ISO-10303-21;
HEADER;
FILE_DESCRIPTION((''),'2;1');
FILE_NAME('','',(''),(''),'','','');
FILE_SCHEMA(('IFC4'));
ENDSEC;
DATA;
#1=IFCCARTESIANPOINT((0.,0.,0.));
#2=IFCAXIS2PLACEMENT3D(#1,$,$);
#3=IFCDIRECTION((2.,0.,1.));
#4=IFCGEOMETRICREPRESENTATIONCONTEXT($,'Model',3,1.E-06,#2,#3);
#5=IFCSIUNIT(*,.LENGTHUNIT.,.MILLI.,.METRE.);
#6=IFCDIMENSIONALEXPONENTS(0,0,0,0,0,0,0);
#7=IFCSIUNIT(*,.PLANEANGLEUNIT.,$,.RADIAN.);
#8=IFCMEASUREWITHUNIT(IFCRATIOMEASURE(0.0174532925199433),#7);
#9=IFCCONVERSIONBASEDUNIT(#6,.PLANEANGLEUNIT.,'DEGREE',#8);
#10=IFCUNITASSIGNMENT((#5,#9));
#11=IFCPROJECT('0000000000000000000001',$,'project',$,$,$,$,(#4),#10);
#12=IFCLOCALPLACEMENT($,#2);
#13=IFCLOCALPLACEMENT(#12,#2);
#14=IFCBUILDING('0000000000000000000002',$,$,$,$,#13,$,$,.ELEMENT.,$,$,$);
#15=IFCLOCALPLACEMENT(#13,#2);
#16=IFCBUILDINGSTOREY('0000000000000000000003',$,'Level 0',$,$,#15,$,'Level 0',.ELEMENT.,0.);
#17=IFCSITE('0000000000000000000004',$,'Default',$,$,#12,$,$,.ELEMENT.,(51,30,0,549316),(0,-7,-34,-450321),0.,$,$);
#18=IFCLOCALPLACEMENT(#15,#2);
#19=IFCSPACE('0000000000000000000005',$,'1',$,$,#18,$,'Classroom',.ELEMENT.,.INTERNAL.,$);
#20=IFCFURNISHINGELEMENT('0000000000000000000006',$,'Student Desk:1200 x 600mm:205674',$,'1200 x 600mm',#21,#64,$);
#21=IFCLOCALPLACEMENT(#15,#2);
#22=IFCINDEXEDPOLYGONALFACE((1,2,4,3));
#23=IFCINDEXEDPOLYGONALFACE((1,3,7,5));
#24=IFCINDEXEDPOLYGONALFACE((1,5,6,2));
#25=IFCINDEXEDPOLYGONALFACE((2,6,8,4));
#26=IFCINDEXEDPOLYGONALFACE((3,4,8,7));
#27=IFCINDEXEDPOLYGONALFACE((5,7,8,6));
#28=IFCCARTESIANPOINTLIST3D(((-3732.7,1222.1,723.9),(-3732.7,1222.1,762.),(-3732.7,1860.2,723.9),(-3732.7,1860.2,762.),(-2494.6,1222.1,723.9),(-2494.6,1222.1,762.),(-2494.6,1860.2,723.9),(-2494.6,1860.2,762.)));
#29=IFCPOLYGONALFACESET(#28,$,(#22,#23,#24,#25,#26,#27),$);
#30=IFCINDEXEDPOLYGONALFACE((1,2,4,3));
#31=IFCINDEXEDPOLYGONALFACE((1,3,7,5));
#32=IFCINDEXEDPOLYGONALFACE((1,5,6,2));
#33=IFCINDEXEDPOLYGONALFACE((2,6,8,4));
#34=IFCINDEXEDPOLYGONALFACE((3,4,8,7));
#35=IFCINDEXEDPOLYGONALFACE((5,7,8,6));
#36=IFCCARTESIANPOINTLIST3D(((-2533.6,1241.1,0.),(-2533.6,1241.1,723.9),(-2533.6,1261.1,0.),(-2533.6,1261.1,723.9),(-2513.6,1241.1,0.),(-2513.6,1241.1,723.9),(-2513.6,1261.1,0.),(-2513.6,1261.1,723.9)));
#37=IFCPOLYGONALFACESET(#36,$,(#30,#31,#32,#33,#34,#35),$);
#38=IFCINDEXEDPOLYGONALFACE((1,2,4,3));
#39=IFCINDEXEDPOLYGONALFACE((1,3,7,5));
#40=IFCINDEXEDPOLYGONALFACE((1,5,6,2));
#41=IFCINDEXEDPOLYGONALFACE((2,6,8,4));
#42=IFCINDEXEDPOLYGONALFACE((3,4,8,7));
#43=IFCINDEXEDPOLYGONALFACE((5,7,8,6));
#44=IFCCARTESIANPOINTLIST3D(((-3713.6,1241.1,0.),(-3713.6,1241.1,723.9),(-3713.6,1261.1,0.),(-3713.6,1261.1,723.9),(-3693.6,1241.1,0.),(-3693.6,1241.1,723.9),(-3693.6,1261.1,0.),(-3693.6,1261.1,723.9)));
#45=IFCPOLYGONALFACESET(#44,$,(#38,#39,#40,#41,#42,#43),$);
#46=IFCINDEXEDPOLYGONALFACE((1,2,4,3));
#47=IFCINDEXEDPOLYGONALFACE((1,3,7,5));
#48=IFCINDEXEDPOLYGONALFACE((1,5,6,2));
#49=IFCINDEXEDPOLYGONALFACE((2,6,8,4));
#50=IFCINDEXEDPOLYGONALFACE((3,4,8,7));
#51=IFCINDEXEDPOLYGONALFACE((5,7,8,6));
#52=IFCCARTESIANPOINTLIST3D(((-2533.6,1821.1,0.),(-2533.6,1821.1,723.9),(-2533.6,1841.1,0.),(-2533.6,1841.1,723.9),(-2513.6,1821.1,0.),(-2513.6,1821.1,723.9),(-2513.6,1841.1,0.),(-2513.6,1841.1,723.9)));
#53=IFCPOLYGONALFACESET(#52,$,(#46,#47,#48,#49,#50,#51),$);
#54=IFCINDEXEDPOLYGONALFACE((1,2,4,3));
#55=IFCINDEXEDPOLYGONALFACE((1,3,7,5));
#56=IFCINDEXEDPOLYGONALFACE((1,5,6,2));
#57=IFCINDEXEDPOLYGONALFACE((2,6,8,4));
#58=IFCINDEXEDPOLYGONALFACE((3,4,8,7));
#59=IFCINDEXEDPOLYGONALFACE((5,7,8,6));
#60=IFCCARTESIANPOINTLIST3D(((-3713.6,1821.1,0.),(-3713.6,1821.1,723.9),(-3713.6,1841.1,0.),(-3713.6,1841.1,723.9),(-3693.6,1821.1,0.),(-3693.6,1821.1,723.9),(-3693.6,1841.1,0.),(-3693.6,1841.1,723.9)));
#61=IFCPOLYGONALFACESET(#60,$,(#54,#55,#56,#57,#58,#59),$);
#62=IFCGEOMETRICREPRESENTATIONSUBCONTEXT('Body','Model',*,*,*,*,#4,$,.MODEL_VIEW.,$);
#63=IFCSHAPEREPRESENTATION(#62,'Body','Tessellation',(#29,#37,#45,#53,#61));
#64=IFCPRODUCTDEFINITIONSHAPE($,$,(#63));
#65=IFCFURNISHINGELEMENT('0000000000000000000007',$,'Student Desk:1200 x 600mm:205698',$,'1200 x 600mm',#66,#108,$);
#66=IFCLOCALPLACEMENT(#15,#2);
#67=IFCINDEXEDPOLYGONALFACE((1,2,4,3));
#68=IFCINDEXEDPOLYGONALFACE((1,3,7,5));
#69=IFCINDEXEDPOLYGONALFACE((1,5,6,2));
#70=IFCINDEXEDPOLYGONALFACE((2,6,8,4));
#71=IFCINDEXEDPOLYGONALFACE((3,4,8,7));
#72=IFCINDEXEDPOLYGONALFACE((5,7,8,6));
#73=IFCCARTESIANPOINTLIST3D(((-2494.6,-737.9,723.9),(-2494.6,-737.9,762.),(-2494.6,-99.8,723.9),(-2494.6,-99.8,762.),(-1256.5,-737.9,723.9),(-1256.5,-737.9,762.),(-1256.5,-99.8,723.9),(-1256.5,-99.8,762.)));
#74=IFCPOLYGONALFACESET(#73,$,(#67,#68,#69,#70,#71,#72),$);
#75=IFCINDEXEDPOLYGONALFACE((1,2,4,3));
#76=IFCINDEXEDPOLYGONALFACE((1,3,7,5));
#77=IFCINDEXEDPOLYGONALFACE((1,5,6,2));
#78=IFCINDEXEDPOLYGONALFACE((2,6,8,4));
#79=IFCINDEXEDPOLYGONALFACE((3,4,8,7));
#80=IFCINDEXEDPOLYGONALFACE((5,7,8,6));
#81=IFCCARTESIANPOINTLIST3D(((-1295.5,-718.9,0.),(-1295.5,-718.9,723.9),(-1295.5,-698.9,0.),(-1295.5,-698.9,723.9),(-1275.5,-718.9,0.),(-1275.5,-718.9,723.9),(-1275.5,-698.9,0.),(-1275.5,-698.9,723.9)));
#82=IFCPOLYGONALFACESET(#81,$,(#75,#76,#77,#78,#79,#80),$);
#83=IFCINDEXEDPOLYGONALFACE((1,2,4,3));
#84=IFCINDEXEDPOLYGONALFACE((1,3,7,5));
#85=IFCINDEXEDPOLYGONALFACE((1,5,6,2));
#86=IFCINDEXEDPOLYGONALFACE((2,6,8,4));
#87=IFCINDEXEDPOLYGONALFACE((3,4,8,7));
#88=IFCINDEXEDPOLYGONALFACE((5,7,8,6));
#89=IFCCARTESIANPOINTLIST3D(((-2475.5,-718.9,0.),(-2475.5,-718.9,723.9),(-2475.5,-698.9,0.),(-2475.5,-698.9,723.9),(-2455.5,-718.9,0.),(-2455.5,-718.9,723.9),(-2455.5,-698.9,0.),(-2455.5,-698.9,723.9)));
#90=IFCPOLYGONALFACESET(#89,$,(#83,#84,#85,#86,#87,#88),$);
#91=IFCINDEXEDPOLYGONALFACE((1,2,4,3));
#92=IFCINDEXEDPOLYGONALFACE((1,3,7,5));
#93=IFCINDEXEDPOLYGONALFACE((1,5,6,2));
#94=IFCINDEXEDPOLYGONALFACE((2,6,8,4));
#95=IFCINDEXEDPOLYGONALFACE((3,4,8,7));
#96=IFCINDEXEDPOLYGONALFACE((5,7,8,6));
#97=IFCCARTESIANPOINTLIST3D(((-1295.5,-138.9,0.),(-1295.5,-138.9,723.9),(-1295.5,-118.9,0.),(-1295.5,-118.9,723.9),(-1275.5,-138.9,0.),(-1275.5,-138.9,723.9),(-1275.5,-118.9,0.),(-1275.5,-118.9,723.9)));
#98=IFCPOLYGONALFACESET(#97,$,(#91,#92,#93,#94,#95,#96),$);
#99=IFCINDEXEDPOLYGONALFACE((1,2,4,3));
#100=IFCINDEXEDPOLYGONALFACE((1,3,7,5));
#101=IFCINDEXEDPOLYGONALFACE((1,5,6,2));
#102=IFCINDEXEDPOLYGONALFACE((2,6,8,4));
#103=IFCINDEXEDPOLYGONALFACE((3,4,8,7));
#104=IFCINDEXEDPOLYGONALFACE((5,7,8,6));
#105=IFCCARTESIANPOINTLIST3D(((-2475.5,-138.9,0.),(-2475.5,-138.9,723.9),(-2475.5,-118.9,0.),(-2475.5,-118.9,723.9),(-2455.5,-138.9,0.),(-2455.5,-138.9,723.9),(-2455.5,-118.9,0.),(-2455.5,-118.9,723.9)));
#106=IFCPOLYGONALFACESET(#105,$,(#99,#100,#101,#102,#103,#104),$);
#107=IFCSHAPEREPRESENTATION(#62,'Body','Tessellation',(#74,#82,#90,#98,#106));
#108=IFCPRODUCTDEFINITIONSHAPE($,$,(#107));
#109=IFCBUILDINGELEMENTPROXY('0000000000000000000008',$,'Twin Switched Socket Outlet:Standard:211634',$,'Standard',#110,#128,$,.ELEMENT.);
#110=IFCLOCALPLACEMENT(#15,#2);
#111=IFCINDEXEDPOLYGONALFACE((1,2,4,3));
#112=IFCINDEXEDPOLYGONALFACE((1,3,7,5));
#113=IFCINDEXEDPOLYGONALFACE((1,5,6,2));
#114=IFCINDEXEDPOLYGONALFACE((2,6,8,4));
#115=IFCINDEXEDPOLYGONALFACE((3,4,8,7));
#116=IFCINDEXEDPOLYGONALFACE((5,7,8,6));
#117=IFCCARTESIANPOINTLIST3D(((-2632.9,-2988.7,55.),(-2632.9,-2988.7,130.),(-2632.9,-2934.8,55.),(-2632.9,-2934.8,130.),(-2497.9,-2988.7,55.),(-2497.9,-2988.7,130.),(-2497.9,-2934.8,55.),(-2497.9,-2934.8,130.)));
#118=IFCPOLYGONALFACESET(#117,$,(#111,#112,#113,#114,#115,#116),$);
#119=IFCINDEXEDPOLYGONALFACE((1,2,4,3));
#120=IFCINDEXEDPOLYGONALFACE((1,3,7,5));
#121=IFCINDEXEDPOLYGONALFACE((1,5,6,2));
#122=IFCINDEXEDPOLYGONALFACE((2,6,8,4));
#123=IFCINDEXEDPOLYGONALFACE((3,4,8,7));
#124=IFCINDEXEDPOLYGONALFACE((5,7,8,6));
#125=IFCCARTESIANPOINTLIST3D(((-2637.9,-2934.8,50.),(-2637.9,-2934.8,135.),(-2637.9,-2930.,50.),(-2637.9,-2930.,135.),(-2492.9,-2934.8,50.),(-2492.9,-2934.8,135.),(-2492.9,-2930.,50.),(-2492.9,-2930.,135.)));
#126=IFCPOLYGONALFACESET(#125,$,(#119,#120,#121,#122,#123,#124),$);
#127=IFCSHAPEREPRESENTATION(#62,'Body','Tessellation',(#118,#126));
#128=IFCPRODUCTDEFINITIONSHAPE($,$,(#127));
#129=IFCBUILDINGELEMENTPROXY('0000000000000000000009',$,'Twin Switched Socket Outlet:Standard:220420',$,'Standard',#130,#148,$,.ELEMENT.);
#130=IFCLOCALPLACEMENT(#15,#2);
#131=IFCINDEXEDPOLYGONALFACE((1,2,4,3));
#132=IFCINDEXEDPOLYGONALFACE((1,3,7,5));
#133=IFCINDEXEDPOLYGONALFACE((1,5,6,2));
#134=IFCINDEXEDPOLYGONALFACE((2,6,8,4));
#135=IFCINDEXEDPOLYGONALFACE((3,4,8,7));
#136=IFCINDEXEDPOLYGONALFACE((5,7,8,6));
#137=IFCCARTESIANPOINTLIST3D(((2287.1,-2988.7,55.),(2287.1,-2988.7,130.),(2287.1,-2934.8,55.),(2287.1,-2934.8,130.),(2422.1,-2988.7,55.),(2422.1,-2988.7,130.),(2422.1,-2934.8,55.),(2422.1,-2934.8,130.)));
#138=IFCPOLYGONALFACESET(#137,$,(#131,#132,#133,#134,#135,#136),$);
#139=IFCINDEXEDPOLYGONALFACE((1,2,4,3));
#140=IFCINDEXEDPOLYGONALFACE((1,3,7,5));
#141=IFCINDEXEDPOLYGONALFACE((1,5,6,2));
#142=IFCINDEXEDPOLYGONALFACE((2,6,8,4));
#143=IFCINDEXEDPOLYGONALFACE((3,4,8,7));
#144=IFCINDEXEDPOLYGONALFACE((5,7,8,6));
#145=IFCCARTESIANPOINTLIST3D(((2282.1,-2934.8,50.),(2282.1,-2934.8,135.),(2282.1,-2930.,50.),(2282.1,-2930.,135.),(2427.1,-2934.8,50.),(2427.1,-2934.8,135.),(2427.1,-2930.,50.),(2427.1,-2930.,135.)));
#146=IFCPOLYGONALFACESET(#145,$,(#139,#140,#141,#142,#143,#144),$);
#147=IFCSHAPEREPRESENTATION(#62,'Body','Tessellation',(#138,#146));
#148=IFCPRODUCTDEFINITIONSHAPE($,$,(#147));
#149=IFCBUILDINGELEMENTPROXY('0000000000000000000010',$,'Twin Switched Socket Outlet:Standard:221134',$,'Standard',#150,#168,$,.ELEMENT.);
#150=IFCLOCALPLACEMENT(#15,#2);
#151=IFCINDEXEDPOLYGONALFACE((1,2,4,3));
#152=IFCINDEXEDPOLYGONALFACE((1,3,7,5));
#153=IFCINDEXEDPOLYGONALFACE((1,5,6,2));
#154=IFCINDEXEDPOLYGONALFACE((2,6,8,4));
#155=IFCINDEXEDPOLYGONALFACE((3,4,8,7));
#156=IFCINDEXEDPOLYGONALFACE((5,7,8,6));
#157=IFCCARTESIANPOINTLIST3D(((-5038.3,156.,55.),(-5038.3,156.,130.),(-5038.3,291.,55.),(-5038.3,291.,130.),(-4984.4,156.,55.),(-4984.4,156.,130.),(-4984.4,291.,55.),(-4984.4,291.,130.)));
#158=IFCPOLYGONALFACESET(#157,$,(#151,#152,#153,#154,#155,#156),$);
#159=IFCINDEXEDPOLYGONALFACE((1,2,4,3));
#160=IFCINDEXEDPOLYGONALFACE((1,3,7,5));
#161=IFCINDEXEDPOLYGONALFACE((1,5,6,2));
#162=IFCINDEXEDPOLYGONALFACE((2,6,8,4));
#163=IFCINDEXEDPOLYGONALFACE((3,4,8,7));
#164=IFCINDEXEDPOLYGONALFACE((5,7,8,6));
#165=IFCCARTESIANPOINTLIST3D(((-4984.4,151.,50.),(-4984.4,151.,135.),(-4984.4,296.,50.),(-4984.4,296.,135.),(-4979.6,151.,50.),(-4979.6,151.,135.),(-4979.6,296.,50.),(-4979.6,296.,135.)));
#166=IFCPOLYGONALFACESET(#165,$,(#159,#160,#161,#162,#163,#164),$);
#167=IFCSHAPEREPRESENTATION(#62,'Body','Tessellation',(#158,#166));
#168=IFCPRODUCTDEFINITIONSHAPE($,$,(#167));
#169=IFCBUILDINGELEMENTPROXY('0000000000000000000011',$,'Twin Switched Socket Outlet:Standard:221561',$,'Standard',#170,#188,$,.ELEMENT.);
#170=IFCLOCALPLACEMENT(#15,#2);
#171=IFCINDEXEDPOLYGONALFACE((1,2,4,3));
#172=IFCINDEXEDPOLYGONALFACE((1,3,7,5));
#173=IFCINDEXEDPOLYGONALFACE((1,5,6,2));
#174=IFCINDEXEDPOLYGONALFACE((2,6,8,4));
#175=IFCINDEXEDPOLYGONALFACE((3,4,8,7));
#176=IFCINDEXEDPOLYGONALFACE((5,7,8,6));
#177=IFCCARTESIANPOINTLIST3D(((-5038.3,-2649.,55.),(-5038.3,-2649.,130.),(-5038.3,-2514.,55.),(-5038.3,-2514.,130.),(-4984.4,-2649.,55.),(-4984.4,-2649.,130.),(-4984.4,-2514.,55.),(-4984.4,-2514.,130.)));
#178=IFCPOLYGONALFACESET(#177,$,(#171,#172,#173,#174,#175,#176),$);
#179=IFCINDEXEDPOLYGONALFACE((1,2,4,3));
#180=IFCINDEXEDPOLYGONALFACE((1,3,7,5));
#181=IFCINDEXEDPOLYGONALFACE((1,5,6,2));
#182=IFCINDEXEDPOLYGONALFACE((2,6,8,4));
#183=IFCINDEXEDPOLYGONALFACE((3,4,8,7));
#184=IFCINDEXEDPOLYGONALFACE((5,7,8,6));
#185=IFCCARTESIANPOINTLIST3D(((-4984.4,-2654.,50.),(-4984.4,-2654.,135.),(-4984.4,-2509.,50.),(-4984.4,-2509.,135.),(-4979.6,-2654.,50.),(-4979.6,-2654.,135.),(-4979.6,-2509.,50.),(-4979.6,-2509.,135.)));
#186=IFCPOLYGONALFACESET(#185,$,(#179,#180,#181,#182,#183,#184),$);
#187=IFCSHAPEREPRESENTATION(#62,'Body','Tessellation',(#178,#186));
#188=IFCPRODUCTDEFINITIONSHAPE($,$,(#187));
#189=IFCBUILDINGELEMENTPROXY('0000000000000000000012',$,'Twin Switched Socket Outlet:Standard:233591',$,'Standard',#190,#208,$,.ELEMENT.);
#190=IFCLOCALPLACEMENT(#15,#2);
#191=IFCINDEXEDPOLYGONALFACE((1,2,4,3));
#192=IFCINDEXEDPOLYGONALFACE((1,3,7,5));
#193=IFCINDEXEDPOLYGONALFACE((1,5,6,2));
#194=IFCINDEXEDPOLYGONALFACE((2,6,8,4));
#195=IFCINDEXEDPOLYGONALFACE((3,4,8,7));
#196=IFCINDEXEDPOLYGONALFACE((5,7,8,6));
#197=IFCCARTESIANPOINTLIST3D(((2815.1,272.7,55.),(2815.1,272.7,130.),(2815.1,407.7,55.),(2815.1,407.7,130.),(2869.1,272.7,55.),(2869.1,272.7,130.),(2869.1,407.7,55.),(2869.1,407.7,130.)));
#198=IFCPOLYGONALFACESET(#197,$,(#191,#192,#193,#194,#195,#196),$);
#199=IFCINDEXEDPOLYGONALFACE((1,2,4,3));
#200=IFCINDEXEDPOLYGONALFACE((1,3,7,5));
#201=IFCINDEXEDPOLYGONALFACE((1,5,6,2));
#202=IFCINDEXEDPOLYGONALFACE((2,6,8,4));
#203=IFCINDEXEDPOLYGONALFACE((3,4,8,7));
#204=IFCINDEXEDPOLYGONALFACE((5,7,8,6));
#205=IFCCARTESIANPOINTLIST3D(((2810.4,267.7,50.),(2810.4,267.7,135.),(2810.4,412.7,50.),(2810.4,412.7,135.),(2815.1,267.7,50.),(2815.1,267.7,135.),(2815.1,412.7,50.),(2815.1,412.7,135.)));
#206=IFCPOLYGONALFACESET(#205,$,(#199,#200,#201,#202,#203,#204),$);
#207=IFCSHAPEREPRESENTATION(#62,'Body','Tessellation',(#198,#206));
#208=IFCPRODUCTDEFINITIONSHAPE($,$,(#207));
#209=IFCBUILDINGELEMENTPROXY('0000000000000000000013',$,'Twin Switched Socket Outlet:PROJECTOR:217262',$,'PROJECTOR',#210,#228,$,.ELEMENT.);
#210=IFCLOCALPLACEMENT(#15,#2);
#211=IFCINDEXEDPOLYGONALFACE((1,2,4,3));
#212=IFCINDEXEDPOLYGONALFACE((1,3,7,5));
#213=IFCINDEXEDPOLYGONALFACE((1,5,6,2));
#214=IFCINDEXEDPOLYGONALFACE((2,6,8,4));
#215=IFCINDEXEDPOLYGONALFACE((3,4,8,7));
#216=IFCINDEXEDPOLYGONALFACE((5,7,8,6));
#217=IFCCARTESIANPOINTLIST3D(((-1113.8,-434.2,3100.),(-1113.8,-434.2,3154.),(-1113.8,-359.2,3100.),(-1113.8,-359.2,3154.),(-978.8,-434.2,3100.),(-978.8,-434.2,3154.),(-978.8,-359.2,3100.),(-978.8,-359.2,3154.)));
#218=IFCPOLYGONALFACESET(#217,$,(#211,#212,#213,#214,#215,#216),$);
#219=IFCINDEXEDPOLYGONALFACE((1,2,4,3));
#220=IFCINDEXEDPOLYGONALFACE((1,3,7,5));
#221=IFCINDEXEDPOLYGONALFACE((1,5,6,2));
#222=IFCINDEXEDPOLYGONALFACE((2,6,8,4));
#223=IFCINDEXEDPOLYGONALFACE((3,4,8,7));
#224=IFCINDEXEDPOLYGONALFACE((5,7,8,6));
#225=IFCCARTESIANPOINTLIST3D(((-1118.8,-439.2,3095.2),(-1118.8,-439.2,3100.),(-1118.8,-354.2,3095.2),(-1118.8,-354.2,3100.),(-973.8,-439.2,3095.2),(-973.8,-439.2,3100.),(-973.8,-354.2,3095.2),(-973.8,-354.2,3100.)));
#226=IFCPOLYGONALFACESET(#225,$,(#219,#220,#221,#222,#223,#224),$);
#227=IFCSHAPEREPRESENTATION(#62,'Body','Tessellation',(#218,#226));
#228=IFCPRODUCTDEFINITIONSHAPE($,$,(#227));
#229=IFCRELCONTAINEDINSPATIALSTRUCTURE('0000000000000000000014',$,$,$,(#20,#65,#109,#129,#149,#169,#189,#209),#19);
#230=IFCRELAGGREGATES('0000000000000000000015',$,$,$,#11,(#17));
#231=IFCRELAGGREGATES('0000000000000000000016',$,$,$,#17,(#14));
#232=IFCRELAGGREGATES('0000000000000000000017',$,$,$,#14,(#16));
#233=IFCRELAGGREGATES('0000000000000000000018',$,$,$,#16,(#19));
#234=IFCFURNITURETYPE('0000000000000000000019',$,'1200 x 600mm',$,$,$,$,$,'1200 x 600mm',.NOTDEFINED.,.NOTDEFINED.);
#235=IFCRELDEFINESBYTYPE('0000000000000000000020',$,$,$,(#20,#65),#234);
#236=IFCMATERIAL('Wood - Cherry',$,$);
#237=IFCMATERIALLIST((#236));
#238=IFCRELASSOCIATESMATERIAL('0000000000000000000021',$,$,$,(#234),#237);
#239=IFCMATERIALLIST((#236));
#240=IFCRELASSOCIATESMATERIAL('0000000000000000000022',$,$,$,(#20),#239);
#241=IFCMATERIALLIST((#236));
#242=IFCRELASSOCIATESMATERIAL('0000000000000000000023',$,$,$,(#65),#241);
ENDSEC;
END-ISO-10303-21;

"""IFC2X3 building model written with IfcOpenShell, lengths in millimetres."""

from ifc_helpers import new_model, entity, si_unit, converted_unit, direction, frame, frame_2d, origin, origin_2d_with_axis, place, context, subcontext, project, spatial, rectangle, extrude, source, transform, mapped, material, material_list, type_object, type_shapes, element, save


model = new_model("IFC2X3")

# Units and contexts
model_context = context("Model", 3, precision=1e-06, world=origin(), true_north=direction((2.0, 0.0, 1.0)))
body_context = subcontext(model_context, "Body", "Model", "MODEL_VIEW")
ifc_project = project(units=[si_unit("LENGTHUNIT", "METRE", prefix="MILLI"), converted_unit("PLANEANGLEUNIT", "DEGREE", entity("IfcRatioMeasure", 0.0174532925199433), si_unit("PLANEANGLEUNIT", "RADIAN"), dimensions=[0, 0, 0, 0, 0, 0, 0])], contexts=[model_context])

# Site, building, storey
site_placement = place(None, origin())
site = spatial("IfcSite", under=ifc_project, at=site_placement, Name="Default", CompositionType="ELEMENT", RefLatitude=(51, 30, 0, 549316), RefLongitude=(0, -7, -34, -450321), RefElevation=0.0)
building_placement = place(site_placement, origin())
building = spatial("IfcBuilding", under=site, at=building_placement, CompositionType="ELEMENT")
storey_placement = place(building_placement, origin())
storey = spatial("IfcBuildingStorey", under=building, at=storey_placement, Name="Level 0", LongName="Level 0", CompositionType="ELEMENT", Elevation=0.0)

# Shared definitions
space_placement = place(storey_placement, origin())
space = spatial("IfcSpace", under=storey, at=space_placement, Name="1", LongName="Classroom", CompositionType="ELEMENT", InteriorOrExteriorSpace="INTERNAL")

# Furnishing elements
ifc_material_1 = material(Name="Wood - Cherry")
ifc_material_list_1 = material_list([ifc_material_1])
furniture_type = type_object("IfcFurnitureType", Name="1200 x 600mm", ElementType="1200 x 600mm", AssemblyPlace="NOTDEFINED", material=ifc_material_list_1)
shared_shape_1 = source(origin(), body_context, "Body", "SweptSolid", [
    extrude(rectangle(XDim=1238.1, YDim=638.1, at=origin_2d_with_axis()), frame((600.0, 300.0, 723.9), z_axis=(0.0, 0.0, 1.0), x_axis=(-1.0, 0.0, 0.0)), (0.0, 0.0, 1.0), 38.1),
    extrude(rectangle(XDim=20.0, YDim=20.0, at=origin_2d_with_axis()), frame((1190.0, 10.0, 0.0)), (0.0, 0.0, 1.0), 723.9),
    extrude(rectangle(XDim=20.0, YDim=20.0, at=frame_2d((0.0, 0.0), x_axis=(1.0, 0.0))), frame((10.0, 10.0, 0.0), z_axis=(0.0, 0.0, 1.0), x_axis=(0.0, 1.0, 0.0)), (0.0, 0.0, 1.0), 723.9),
    extrude(rectangle(XDim=20.0, YDim=20.0, at=frame_2d((0.0, 0.0), x_axis=(1.0, 0.0))), frame((1190.0, 590.0, 0.0), z_axis=(0.0, 0.0, 1.0), x_axis=(0.0, -1.0, 0.0)), (0.0, 0.0, 1.0), 723.9),
    extrude(rectangle(XDim=20.0, YDim=20.0, at=origin_2d_with_axis()), frame((10.0, 590.0, 0.0), z_axis=(0.0, 0.0, 1.0), x_axis=(-1.0, 0.0, 0.0)), (0.0, 0.0, 1.0), 723.9),
])
type_shapes(furniture_type, [shared_shape_1])
ifc_material_list_2 = material_list([ifc_material_1])
furnishing_1_placement = place(space_placement, frame((-3713.6, 1241.1, 0.0)))
element("IfcFurnishingElement", 1, at=furnishing_1_placement, inside=space, type_object=furniture_type, material=ifc_material_list_2, Name="Student Desk:1200 x 600mm:205674", ObjectType="1200 x 600mm", context=body_context, shape_type="MappedRepresentation", body=[
    mapped(shared_shape_1, transform((0.0, 0.0, 0.0), scale=1.0)),
])
ifc_material_list_3 = material_list([ifc_material_1])
furnishing_2_placement = place(space_placement, frame((-2475.5, -718.9, 0.0)))
element("IfcFurnishingElement", 2, at=furnishing_2_placement, inside=space, type_object=furniture_type, material=ifc_material_list_3, Name="Student Desk:1200 x 600mm:205698", ObjectType="1200 x 600mm", context=body_context, shape_type="MappedRepresentation", body=[
    mapped(shared_shape_1, transform((0.0, 0.0, 0.0), scale=1.0)),
])

# Building element proxies
shared_shape_2 = source(origin(), body_context, "Body", "SweptSolid", [
    extrude(rectangle(XDim=135.0, YDim=75.0, at=origin_2d_with_axis()), frame((0.0, 0.0, -54.0), z_axis=(0.0, 0.0, 1.0), x_axis=(-1.0, 0.0, 0.0)), (0.0, 0.0, 1.0), 54.0),
    extrude(rectangle(XDim=145.0, YDim=85.0, at=origin_2d_with_axis()), frame((0.0, 0.0, 0.0), z_axis=(0.0, 0.0, 1.0), x_axis=(-1.0, 0.0, 0.0)), (0.0, 0.0, 1.0), 4.8),
])
for number, where, z_axis, x_axis, name in (
    (3, (-2565.4, -2934.8, 92.5), (0.0, 1.0, 0.0), (-1.0, 0.0, 0.0), "Twin Switched Socket Outlet:Standard:211634"),
    (4, (2354.6, -2934.8, 92.5), (0.0, 1.0, 0.0), (-1.0, 0.0, 0.0), "Twin Switched Socket Outlet:Standard:220420"),
    (5, (-4984.4, 223.5, 92.5), (1.0, 0.0, 0.0), (0.0, 1.0, 0.0), "Twin Switched Socket Outlet:Standard:221134"),
    (6, (-4984.4, -2581.5, 92.5), (1.0, 0.0, 0.0), (0.0, 1.0, 0.0), "Twin Switched Socket Outlet:Standard:221561"),
    (7, (2815.1, 340.2, 92.5), (-1.0, 0.0, 0.0), (0.0, -1.0, 0.0), "Twin Switched Socket Outlet:Standard:233591"),
):
    element("IfcBuildingElementProxy", number, at=place(space_placement, frame(where, z_axis=z_axis, x_axis=x_axis)), inside=space, Name=name, ObjectType="Standard", CompositionType="ELEMENT", context=body_context, shape_type="MappedRepresentation", body=[
        mapped(shared_shape_2, transform((0.0, 0.0, 0.0), scale=1.0)),
    ])
shared_shape_3 = source(origin(), body_context, "Body", "SweptSolid", [
    extrude(rectangle(XDim=135.0, YDim=75.0, at=origin_2d_with_axis()), frame((0.0, 0.0, -54.0), z_axis=(0.0, 0.0, 1.0), x_axis=(-1.0, 0.0, 0.0)), (0.0, 0.0, 1.0), 54.0),
    extrude(rectangle(XDim=145.0, YDim=85.0, at=origin_2d_with_axis()), frame((0.0, 0.0, 0.0), z_axis=(0.0, 0.0, 1.0), x_axis=(-1.0, 0.0, 0.0)), (0.0, 0.0, 1.0), 4.8),
])
proxy_1_placement = place(space_placement, frame((-1046.3, -396.7, 3100.0), z_axis=(0.0, 0.0, -1.0), x_axis=(1.0, 0.0, 0.0)))
element("IfcBuildingElementProxy", 8, at=proxy_1_placement, inside=space, Name="Twin Switched Socket Outlet:PROJECTOR:217262", ObjectType="PROJECTOR", CompositionType="ELEMENT", context=body_context, shape_type="MappedRepresentation", body=[
    mapped(shared_shape_3, transform((0.0, 0.0, 0.0), scale=1.0)),
])

save(model, "model.ifc")
